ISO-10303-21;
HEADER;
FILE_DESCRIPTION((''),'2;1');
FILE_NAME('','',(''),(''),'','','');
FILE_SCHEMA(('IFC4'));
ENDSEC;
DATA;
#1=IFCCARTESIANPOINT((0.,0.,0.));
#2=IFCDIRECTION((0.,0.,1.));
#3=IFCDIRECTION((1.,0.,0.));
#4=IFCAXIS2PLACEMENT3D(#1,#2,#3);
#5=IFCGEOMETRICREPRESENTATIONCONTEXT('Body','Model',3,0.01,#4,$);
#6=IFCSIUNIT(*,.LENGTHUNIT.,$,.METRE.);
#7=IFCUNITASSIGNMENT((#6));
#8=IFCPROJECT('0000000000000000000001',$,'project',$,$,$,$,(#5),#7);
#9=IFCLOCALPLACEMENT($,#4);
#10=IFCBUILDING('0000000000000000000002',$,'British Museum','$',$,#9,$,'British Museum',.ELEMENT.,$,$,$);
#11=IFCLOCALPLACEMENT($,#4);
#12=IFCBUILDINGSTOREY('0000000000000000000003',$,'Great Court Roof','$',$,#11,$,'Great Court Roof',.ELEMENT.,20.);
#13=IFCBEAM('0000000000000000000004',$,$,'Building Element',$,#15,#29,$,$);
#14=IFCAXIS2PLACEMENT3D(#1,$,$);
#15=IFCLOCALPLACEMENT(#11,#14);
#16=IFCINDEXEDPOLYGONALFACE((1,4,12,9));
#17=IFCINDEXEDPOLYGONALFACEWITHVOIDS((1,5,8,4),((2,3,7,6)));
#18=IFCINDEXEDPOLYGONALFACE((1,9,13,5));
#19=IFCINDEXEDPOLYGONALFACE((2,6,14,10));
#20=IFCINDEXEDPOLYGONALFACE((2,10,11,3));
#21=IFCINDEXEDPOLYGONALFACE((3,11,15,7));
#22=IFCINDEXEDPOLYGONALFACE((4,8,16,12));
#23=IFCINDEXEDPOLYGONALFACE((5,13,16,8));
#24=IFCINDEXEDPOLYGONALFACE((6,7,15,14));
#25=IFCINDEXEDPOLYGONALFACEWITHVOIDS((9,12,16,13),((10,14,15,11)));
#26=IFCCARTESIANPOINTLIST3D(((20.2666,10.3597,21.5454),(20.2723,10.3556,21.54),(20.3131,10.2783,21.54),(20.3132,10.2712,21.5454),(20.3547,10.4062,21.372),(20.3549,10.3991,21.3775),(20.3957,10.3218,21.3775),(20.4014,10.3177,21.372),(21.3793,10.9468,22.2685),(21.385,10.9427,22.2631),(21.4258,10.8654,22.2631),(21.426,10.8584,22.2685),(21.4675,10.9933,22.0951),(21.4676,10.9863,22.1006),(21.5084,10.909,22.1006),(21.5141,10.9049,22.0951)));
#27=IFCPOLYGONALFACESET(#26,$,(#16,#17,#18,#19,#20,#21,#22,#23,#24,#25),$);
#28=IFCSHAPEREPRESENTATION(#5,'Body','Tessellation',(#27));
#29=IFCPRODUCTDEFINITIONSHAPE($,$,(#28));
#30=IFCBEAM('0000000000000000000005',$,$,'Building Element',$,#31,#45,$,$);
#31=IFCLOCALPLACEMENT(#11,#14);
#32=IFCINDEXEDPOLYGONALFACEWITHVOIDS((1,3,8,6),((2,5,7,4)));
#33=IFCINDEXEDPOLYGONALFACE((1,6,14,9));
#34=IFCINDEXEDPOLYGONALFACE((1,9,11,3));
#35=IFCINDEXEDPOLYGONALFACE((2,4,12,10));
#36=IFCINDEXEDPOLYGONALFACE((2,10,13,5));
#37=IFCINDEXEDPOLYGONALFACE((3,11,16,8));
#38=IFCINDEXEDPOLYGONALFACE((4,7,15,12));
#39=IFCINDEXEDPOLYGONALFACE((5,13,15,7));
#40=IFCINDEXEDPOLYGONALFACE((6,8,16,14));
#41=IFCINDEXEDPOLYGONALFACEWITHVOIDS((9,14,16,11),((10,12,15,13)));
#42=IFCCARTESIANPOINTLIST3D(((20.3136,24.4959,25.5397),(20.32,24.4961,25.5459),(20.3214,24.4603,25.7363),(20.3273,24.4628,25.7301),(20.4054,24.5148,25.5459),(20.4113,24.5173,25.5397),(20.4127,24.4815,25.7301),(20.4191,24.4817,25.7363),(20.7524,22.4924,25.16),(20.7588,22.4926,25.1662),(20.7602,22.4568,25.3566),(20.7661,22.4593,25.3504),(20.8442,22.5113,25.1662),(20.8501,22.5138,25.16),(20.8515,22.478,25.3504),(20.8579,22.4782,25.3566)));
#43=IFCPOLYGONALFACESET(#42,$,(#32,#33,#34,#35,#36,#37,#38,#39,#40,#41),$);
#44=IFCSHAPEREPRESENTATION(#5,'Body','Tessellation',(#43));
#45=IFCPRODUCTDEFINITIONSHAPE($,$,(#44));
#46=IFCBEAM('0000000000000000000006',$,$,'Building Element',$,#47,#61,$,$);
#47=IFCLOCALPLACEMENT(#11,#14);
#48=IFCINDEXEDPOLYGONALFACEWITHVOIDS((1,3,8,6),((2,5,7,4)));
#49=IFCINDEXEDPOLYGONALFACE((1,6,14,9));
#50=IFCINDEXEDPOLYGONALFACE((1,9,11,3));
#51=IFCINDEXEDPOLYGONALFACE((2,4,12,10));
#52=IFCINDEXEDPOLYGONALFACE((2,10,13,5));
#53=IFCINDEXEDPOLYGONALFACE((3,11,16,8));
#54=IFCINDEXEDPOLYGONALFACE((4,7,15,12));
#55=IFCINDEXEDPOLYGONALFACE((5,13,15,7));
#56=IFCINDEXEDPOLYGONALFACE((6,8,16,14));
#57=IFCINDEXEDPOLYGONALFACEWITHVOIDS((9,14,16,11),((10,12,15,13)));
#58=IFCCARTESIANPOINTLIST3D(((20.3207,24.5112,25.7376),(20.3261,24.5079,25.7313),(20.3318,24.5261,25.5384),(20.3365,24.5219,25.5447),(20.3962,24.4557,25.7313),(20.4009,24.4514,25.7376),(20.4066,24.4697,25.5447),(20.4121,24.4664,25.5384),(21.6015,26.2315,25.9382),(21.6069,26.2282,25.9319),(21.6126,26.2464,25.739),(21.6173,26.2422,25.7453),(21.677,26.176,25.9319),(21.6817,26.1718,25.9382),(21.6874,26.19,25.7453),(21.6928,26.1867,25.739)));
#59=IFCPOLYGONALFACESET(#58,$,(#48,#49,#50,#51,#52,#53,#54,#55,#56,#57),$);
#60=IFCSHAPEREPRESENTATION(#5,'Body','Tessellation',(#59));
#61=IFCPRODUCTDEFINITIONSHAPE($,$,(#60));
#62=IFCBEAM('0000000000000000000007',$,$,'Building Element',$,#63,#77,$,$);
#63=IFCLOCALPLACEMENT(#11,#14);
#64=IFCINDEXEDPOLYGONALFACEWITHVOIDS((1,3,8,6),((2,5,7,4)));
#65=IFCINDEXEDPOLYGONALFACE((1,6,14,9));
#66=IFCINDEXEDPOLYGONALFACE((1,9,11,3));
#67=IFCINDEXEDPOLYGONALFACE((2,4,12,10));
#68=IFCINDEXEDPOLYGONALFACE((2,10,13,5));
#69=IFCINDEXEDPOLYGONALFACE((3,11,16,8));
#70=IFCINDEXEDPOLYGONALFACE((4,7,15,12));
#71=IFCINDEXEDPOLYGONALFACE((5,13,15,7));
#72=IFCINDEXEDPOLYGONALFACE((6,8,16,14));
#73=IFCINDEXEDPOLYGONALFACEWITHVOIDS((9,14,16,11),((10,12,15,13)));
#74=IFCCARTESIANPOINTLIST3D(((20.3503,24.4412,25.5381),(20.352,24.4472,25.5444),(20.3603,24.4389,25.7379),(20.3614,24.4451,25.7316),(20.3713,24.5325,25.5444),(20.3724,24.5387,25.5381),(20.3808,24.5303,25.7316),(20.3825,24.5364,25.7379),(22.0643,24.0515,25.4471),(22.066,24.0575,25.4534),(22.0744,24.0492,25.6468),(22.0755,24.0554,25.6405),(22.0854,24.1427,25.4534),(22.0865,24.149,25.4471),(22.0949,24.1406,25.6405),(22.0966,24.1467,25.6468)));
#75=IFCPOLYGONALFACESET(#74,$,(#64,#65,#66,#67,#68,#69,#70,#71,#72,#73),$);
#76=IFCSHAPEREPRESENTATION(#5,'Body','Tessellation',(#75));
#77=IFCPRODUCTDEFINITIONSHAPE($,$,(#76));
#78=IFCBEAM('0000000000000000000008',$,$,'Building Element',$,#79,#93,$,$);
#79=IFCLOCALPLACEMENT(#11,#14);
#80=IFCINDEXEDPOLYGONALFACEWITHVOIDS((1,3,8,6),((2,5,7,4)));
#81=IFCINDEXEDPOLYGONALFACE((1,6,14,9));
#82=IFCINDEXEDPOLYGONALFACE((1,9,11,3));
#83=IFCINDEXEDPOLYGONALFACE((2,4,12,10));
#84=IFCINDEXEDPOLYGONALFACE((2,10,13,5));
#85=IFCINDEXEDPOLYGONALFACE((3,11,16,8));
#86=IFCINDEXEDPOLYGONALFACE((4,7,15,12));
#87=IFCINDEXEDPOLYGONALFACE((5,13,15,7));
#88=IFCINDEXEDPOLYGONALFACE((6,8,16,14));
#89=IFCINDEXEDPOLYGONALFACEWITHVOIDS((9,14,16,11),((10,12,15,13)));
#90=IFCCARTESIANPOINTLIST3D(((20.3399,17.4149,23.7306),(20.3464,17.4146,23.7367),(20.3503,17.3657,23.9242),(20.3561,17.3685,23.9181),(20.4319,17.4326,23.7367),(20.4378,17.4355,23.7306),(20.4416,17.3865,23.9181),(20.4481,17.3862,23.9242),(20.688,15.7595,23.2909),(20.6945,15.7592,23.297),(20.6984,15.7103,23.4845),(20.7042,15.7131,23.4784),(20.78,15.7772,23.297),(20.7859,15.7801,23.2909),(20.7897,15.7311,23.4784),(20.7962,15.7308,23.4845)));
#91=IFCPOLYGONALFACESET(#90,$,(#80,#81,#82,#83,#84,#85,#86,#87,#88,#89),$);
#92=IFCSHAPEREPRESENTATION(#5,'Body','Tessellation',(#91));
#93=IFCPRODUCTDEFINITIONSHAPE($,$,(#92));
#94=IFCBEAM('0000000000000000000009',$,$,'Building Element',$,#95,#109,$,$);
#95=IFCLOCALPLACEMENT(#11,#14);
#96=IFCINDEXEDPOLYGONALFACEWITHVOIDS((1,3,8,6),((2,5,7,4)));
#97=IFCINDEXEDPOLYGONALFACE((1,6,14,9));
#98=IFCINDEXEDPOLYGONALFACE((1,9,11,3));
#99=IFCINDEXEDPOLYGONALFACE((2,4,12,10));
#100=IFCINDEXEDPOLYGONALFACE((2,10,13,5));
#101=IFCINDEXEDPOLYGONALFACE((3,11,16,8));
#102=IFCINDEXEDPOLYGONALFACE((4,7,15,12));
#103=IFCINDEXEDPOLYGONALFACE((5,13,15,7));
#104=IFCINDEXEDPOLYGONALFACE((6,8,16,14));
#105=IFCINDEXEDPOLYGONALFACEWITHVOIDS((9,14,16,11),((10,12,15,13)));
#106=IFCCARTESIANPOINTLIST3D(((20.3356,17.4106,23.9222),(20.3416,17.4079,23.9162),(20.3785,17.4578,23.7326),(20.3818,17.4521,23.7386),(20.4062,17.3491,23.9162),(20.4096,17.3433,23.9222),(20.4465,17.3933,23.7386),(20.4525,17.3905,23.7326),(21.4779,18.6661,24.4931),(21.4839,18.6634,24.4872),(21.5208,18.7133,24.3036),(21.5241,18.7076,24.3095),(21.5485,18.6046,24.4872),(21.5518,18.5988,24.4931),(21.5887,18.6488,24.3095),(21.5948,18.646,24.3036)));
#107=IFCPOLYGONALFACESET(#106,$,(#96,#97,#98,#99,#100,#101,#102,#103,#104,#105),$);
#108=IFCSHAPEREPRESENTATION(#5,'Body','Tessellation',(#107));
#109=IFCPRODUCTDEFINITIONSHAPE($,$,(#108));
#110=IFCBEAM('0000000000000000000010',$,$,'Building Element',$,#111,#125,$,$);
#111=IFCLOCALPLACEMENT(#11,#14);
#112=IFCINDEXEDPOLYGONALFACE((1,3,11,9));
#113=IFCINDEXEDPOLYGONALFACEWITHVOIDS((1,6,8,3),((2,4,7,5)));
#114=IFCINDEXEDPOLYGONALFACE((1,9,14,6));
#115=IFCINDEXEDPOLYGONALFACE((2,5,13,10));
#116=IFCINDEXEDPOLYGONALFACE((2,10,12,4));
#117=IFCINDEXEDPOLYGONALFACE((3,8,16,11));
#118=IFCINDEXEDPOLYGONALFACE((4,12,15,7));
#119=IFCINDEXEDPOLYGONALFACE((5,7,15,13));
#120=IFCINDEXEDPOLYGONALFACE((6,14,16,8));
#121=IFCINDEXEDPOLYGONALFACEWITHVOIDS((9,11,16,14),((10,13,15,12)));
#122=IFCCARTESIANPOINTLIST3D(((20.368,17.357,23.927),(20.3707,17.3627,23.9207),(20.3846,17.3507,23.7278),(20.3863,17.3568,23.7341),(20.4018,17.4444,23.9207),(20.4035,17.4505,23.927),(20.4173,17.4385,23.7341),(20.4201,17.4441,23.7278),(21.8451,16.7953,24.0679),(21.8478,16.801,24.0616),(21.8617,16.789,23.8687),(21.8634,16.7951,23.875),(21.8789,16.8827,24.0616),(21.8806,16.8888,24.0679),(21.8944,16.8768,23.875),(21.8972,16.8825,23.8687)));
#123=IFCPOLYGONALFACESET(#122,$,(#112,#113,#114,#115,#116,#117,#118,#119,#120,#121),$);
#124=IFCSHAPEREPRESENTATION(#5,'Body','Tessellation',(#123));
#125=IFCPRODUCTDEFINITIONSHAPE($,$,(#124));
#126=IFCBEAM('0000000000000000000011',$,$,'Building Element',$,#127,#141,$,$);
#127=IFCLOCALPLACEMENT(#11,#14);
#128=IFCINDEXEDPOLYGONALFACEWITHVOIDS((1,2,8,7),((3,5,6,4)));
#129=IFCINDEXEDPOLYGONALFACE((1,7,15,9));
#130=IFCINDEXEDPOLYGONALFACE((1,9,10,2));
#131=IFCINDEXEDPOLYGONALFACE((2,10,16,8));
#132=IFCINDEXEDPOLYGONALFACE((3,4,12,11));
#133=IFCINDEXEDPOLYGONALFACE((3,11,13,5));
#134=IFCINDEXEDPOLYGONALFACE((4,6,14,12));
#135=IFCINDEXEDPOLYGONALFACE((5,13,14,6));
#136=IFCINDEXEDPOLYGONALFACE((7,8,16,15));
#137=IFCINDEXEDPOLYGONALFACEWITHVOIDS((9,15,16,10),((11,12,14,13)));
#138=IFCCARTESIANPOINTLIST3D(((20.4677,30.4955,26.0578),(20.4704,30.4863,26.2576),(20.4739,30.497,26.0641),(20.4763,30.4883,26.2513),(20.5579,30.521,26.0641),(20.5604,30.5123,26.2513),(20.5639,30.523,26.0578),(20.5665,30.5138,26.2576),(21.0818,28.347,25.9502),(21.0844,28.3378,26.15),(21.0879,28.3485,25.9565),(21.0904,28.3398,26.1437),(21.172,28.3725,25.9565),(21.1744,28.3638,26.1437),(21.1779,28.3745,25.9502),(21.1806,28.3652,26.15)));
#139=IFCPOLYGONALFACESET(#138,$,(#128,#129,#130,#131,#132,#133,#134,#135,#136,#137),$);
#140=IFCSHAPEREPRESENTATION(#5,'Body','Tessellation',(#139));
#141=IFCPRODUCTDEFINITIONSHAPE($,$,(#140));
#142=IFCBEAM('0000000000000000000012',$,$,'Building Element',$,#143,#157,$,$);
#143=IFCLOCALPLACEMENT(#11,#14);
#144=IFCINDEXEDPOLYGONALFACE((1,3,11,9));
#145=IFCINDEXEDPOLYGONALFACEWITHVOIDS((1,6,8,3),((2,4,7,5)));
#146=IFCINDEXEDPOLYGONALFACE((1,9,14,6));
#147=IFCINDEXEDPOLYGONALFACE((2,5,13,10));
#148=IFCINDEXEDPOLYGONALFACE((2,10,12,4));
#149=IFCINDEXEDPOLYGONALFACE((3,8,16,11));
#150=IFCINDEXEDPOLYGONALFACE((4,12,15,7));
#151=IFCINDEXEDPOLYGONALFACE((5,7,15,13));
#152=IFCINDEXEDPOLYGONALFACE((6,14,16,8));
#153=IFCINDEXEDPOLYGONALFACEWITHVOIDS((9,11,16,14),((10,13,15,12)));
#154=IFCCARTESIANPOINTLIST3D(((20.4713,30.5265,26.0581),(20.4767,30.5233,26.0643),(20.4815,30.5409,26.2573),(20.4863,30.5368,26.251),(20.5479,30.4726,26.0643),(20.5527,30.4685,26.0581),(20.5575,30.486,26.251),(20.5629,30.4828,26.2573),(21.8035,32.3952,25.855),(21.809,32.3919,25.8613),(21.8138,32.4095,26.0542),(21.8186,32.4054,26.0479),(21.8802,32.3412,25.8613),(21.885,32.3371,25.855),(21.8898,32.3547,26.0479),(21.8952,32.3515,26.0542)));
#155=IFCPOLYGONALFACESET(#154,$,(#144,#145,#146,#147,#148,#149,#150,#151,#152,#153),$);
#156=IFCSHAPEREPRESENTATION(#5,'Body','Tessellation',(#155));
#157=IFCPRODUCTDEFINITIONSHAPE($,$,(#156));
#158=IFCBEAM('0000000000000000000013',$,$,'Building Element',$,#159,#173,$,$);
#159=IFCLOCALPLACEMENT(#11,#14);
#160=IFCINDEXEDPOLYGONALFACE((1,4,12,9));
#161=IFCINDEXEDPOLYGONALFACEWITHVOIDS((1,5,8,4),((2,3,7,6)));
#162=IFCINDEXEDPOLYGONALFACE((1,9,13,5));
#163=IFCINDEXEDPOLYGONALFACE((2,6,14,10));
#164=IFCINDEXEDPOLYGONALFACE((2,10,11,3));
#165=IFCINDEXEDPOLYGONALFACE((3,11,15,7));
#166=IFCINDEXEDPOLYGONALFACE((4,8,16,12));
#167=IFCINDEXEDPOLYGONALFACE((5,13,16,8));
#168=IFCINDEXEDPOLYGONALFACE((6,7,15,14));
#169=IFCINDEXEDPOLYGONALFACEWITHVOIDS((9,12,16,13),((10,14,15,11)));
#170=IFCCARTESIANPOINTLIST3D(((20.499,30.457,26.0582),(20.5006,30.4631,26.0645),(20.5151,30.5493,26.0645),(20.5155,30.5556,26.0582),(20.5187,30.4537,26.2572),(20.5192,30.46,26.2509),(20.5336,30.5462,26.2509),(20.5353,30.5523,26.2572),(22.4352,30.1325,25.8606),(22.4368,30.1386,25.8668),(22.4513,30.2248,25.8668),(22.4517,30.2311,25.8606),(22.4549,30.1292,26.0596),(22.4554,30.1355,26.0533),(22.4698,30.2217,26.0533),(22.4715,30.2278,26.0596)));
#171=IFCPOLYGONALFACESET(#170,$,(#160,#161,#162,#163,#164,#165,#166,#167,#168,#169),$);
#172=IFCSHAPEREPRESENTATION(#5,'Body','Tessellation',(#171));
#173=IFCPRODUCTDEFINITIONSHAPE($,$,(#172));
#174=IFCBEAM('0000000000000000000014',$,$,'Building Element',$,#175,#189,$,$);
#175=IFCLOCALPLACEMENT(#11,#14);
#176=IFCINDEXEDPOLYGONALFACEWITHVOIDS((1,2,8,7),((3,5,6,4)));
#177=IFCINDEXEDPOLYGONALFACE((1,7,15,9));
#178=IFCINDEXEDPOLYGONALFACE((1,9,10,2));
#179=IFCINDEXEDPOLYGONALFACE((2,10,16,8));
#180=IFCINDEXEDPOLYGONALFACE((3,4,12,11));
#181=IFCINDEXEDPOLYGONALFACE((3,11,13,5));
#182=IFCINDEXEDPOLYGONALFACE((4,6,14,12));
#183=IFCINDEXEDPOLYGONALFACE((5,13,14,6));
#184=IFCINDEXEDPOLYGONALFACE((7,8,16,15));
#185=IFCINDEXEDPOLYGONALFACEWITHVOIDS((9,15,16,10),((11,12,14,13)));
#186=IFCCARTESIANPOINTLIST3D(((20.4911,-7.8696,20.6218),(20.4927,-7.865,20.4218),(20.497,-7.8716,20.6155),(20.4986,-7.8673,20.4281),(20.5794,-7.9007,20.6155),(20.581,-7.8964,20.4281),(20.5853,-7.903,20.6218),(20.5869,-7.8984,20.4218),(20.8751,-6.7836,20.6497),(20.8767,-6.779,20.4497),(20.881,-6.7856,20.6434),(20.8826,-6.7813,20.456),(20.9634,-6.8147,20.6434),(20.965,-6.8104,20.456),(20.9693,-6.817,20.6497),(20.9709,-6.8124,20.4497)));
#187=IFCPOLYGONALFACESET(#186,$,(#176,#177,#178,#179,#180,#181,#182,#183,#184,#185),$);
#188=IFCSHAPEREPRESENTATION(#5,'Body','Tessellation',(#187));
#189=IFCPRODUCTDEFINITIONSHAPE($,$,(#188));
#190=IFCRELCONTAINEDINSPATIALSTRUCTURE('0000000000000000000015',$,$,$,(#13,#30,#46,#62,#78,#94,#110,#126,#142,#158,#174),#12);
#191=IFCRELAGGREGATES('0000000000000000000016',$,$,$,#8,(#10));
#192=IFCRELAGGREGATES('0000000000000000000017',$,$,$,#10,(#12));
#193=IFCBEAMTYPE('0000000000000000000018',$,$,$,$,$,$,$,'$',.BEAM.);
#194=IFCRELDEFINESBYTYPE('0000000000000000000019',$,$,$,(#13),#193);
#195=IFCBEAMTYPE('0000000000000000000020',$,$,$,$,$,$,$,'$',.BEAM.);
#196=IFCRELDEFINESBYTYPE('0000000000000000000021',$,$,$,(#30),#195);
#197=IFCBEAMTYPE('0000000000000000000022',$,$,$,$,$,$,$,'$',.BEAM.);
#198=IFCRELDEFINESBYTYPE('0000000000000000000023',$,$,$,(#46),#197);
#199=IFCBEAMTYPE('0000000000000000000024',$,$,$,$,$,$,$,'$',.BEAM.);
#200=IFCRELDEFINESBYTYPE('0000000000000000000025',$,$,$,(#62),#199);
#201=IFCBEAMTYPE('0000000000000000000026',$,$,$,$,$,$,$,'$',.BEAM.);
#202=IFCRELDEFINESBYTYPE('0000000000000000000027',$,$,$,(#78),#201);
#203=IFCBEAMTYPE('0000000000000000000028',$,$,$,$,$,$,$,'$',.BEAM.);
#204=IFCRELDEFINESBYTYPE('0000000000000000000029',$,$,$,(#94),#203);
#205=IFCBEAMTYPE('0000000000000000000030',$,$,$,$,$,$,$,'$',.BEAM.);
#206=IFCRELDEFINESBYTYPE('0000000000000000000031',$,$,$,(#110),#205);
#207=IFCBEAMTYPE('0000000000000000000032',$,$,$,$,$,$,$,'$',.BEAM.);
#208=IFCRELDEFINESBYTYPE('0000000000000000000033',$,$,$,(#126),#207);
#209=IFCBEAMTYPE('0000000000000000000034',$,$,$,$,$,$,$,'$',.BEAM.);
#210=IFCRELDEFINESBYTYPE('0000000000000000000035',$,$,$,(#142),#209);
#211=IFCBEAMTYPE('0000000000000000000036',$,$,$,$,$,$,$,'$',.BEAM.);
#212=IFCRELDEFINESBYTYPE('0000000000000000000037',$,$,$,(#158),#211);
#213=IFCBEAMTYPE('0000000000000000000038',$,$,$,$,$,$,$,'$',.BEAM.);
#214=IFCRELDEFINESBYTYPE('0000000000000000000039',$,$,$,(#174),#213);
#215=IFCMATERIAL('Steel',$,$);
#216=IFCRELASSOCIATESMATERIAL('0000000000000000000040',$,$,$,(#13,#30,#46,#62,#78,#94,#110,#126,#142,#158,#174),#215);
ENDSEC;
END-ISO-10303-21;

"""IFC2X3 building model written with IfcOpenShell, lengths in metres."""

from ifc_helpers import new_model, si_unit, frame, origin_with_axes, origin_2d, place, context, project, spatial, hollow_rectangle, extrude, material, type_object, element, save


model = new_model("IFC2X3")

# Units and contexts
model_context = context("Model", 3, precision=0.01, world=origin_with_axes(), identifier="Body")
ifc_project = project(units=[si_unit("LENGTHUNIT", "METRE")], contexts=[model_context])

# Building, storey
building_placement = place(None, origin_with_axes())
building = spatial("IfcBuilding", under=ifc_project, at=building_placement, Name="British Museum", Description="$", LongName="British Museum", CompositionType="ELEMENT")
storey_placement = place(None, origin_with_axes())
storey = spatial("IfcBuildingStorey", under=building, at=storey_placement, Name="Great Court Roof", Description="$", LongName="Great Court Roof", CompositionType="ELEMENT", Elevation=20.0)

# Beams
ifc_material = material(Name="Steel")
beam_type_1 = type_object("IfcBeamType", ElementType="$", PredefinedType="BEAM")
beam_1_placement = place(None, origin_with_axes())
element("IfcBeam", 1, at=beam_1_placement, inside=storey, type_object=beam_type_1, material=ifc_material, Description="Building Element", context=model_context, shape_type="SweptSolid", body=[
    extrude(hollow_rectangle(XDim=0.1, YDim=0.2, WallThickness=0.0063, InnerFilletRadius=-0.0063, OuterFilletRadius=0.0, at=origin_2d()), frame((20.334, 10.3387, 21.4587), z_axis=(0.766806, 0.404609, 0.498297), x_axis=(-0.466673, 0.88443, 0.0)), (0.0, 0.0, 1.0), 1.4512),
])
beam_type_2 = type_object("IfcBeamType", ElementType="$", PredefinedType="BEAM")
beam_2_placement = place(None, origin_with_axes())
element("IfcBeam", 2, at=beam_2_placement, inside=storey, type_object=beam_type_2, material=ifc_material, Description="Building Element", context=model_context, shape_type="SweptSolid", body=[
    extrude(hollow_rectangle(XDim=0.1, YDim=0.2, WallThickness=0.0063, InnerFilletRadius=-0.0063, OuterFilletRadius=0.0, at=origin_2d()), frame((20.3664, 24.4888, 25.638), z_axis=(0.210363, -0.960524, -0.182045), x_axis=(0.976847, 0.213937, 0.0)), (0.0, 0.0, 1.0), 2.0858),
])
beam_type_3 = type_object("IfcBeamType", ElementType="$", PredefinedType="BEAM")
beam_3_placement = place(None, origin_with_axes())
element("IfcBeam", 3, at=beam_3_placement, inside=storey, type_object=beam_type_3, material=ifc_material, Description="Building Element", context=model_context, shape_type="SweptSolid", body=[
    extrude(hollow_rectangle(XDim=0.1, YDim=0.2, WallThickness=0.0063, InnerFilletRadius=-0.0063, OuterFilletRadius=0.0, at=origin_2d()), frame((20.3664, 24.4888, 25.638), z_axis=(0.594578, 0.798628, 0.093118), x_axis=(-0.802113, 0.597172, 0.0)), (0.0, 0.0, 1.0), 2.1541),
])
beam_type_4 = type_object("IfcBeamType", ElementType="$", PredefinedType="BEAM")
beam_4_placement = place(None, origin_with_axes())
element("IfcBeam", 4, at=beam_4_placement, inside=storey, type_object=beam_type_4, material=ifc_material, Description="Building Element", context=model_context, shape_type="SweptSolid", body=[
    extrude(hollow_rectangle(XDim=0.1, YDim=0.2, WallThickness=0.0063, InnerFilletRadius=-0.0063, OuterFilletRadius=0.0, at=origin_2d()), frame((20.3664, 24.4888, 25.638), z_axis=(0.973809, -0.221406, -0.051723), x_axis=(0.221702, 0.975114, 0.0)), (0.0, 0.0, 1.0), 1.7602),
])
beam_type_5 = type_object("IfcBeamType", ElementType="$", PredefinedType="BEAM")
beam_5_placement = place(None, origin_with_axes())
element("IfcBeam", 5, at=beam_5_placement, inside=storey, type_object=beam_type_5, material=ifc_material, Description="Building Element", context=model_context, shape_type="SweptSolid", body=[
    extrude(hollow_rectangle(XDim=0.1, YDim=0.2, WallThickness=0.0063, InnerFilletRadius=-0.0063, OuterFilletRadius=0.0, at=origin_2d()), frame((20.394, 17.4006, 23.8274), z_axis=(0.199159, -0.94713, -0.251556), x_axis=(0.978599, 0.205776, 0.0)), (0.0, 0.0, 1.0), 1.7478),
])
beam_type_6 = type_object("IfcBeamType", ElementType="$", PredefinedType="BEAM")
beam_6_placement = place(None, origin_with_axes())
element("IfcBeam", 6, at=beam_6_placement, inside=storey, type_object=beam_type_6, material=ifc_material, Description="Building Element", context=model_context, shape_type="SweptSolid", body=[
    extrude(hollow_rectangle(XDim=0.1, YDim=0.2, WallThickness=0.0063, InnerFilletRadius=-0.0063, OuterFilletRadius=0.0, at=origin_2d()), frame((20.394, 17.4006, 23.8274), z_axis=(0.637854, 0.701069, 0.318818), x_axis=(-0.739668, 0.672972, 0.0)), (0.0, 0.0, 1.0), 1.7908),
])
beam_type_7 = type_object("IfcBeamType", ElementType="$", PredefinedType="BEAM")
beam_7_placement = place(None, origin_with_axes())
element("IfcBeam", 7, at=beam_7_placement, inside=storey, type_object=beam_type_7, material=ifc_material, Description="Building Element", context=model_context, shape_type="SweptSolid", body=[
    extrude(hollow_rectangle(XDim=0.1, YDim=0.2, WallThickness=0.0063, InnerFilletRadius=-0.0063, OuterFilletRadius=0.0, at=origin_2d()), frame((20.394, 17.4006, 23.8274), z_axis=(0.931013, -0.354017, 0.088809), x_axis=(0.355421, 0.934706, 0.0)), (0.0, 0.0, 1.0), 1.5866),
])
beam_type_8 = type_object("IfcBeamType", ElementType="$", PredefinedType="BEAM")
beam_8_placement = place(None, origin_with_axes())
element("IfcBeam", 8, at=beam_8_placement, inside=storey, type_object=beam_type_8, material=ifc_material, Description="Building Element", context=model_context, shape_type="SweptSolid", body=[
    extrude(hollow_rectangle(XDim=0.1, YDim=0.2, WallThickness=0.0063, InnerFilletRadius=-0.0063, OuterFilletRadius=0.0, at=origin_2d()), frame((20.5171, 30.5047, 26.1577), z_axis=(0.274483, -0.960389, -0.048092), x_axis=(0.961501, 0.274801, 0.0)), (0.0, 0.0, 1.0), 2.2371),
])
beam_type_9 = type_object("IfcBeamType", ElementType="$", PredefinedType="BEAM")
beam_9_placement = place(None, origin_with_axes())
element("IfcBeam", 9, at=beam_9_placement, inside=storey, type_object=beam_type_9, material=ifc_material, Description="Building Element", context=model_context, shape_type="SweptSolid", body=[
    extrude(hollow_rectangle(XDim=0.1, YDim=0.2, WallThickness=0.0063, InnerFilletRadius=-0.0063, OuterFilletRadius=0.0, at=origin_2d()), frame((20.5171, 30.5047, 26.1577), z_axis=(0.57826, 0.811077, -0.088145), x_axis=(-0.814246, 0.58052, 0.0)), (0.0, 0.0, 1.0), 2.3039),
])
beam_type_10 = type_object("IfcBeamType", ElementType="$", PredefinedType="BEAM")
beam_10_placement = place(None, origin_with_axes())
element("IfcBeam", 10, at=beam_10_placement, inside=storey, type_object=beam_type_10, material=ifc_material, Description="Building Element", context=model_context, shape_type="SweptSolid", body=[
    extrude(hollow_rectangle(XDim=0.1, YDim=0.2, WallThickness=0.0063, InnerFilletRadius=-0.0063, OuterFilletRadius=0.0, at=origin_2d()), frame((20.5171, 30.5047, 26.1577), z_axis=(0.981286, -0.164457, -0.100156), x_axis=(0.165288, 0.986245, 0.0)), (0.0, 0.0, 1.0), 1.9731),
])
beam_type_11 = type_object("IfcBeamType", ElementType="$", PredefinedType="BEAM")
beam_11_placement = place(None, origin_with_axes())
element("IfcBeam", 11, at=beam_11_placement, inside=storey, type_object=beam_type_11, material=ifc_material, Description="Building Element", context=model_context, shape_type="SweptSolid", body=[
    extrude(hollow_rectangle(XDim=0.1, YDim=0.2, WallThickness=0.0063, InnerFilletRadius=-0.0063, OuterFilletRadius=0.0, at=origin_2d()), frame((20.539, -7.884, 20.5218), z_axis=(0.333267, 0.942521, 0.024217), x_axis=(-0.942798, 0.333365, 0.0)), (0.0, 0.0, 1.0), 1.1522),
])

save(model, "model.ifc")
